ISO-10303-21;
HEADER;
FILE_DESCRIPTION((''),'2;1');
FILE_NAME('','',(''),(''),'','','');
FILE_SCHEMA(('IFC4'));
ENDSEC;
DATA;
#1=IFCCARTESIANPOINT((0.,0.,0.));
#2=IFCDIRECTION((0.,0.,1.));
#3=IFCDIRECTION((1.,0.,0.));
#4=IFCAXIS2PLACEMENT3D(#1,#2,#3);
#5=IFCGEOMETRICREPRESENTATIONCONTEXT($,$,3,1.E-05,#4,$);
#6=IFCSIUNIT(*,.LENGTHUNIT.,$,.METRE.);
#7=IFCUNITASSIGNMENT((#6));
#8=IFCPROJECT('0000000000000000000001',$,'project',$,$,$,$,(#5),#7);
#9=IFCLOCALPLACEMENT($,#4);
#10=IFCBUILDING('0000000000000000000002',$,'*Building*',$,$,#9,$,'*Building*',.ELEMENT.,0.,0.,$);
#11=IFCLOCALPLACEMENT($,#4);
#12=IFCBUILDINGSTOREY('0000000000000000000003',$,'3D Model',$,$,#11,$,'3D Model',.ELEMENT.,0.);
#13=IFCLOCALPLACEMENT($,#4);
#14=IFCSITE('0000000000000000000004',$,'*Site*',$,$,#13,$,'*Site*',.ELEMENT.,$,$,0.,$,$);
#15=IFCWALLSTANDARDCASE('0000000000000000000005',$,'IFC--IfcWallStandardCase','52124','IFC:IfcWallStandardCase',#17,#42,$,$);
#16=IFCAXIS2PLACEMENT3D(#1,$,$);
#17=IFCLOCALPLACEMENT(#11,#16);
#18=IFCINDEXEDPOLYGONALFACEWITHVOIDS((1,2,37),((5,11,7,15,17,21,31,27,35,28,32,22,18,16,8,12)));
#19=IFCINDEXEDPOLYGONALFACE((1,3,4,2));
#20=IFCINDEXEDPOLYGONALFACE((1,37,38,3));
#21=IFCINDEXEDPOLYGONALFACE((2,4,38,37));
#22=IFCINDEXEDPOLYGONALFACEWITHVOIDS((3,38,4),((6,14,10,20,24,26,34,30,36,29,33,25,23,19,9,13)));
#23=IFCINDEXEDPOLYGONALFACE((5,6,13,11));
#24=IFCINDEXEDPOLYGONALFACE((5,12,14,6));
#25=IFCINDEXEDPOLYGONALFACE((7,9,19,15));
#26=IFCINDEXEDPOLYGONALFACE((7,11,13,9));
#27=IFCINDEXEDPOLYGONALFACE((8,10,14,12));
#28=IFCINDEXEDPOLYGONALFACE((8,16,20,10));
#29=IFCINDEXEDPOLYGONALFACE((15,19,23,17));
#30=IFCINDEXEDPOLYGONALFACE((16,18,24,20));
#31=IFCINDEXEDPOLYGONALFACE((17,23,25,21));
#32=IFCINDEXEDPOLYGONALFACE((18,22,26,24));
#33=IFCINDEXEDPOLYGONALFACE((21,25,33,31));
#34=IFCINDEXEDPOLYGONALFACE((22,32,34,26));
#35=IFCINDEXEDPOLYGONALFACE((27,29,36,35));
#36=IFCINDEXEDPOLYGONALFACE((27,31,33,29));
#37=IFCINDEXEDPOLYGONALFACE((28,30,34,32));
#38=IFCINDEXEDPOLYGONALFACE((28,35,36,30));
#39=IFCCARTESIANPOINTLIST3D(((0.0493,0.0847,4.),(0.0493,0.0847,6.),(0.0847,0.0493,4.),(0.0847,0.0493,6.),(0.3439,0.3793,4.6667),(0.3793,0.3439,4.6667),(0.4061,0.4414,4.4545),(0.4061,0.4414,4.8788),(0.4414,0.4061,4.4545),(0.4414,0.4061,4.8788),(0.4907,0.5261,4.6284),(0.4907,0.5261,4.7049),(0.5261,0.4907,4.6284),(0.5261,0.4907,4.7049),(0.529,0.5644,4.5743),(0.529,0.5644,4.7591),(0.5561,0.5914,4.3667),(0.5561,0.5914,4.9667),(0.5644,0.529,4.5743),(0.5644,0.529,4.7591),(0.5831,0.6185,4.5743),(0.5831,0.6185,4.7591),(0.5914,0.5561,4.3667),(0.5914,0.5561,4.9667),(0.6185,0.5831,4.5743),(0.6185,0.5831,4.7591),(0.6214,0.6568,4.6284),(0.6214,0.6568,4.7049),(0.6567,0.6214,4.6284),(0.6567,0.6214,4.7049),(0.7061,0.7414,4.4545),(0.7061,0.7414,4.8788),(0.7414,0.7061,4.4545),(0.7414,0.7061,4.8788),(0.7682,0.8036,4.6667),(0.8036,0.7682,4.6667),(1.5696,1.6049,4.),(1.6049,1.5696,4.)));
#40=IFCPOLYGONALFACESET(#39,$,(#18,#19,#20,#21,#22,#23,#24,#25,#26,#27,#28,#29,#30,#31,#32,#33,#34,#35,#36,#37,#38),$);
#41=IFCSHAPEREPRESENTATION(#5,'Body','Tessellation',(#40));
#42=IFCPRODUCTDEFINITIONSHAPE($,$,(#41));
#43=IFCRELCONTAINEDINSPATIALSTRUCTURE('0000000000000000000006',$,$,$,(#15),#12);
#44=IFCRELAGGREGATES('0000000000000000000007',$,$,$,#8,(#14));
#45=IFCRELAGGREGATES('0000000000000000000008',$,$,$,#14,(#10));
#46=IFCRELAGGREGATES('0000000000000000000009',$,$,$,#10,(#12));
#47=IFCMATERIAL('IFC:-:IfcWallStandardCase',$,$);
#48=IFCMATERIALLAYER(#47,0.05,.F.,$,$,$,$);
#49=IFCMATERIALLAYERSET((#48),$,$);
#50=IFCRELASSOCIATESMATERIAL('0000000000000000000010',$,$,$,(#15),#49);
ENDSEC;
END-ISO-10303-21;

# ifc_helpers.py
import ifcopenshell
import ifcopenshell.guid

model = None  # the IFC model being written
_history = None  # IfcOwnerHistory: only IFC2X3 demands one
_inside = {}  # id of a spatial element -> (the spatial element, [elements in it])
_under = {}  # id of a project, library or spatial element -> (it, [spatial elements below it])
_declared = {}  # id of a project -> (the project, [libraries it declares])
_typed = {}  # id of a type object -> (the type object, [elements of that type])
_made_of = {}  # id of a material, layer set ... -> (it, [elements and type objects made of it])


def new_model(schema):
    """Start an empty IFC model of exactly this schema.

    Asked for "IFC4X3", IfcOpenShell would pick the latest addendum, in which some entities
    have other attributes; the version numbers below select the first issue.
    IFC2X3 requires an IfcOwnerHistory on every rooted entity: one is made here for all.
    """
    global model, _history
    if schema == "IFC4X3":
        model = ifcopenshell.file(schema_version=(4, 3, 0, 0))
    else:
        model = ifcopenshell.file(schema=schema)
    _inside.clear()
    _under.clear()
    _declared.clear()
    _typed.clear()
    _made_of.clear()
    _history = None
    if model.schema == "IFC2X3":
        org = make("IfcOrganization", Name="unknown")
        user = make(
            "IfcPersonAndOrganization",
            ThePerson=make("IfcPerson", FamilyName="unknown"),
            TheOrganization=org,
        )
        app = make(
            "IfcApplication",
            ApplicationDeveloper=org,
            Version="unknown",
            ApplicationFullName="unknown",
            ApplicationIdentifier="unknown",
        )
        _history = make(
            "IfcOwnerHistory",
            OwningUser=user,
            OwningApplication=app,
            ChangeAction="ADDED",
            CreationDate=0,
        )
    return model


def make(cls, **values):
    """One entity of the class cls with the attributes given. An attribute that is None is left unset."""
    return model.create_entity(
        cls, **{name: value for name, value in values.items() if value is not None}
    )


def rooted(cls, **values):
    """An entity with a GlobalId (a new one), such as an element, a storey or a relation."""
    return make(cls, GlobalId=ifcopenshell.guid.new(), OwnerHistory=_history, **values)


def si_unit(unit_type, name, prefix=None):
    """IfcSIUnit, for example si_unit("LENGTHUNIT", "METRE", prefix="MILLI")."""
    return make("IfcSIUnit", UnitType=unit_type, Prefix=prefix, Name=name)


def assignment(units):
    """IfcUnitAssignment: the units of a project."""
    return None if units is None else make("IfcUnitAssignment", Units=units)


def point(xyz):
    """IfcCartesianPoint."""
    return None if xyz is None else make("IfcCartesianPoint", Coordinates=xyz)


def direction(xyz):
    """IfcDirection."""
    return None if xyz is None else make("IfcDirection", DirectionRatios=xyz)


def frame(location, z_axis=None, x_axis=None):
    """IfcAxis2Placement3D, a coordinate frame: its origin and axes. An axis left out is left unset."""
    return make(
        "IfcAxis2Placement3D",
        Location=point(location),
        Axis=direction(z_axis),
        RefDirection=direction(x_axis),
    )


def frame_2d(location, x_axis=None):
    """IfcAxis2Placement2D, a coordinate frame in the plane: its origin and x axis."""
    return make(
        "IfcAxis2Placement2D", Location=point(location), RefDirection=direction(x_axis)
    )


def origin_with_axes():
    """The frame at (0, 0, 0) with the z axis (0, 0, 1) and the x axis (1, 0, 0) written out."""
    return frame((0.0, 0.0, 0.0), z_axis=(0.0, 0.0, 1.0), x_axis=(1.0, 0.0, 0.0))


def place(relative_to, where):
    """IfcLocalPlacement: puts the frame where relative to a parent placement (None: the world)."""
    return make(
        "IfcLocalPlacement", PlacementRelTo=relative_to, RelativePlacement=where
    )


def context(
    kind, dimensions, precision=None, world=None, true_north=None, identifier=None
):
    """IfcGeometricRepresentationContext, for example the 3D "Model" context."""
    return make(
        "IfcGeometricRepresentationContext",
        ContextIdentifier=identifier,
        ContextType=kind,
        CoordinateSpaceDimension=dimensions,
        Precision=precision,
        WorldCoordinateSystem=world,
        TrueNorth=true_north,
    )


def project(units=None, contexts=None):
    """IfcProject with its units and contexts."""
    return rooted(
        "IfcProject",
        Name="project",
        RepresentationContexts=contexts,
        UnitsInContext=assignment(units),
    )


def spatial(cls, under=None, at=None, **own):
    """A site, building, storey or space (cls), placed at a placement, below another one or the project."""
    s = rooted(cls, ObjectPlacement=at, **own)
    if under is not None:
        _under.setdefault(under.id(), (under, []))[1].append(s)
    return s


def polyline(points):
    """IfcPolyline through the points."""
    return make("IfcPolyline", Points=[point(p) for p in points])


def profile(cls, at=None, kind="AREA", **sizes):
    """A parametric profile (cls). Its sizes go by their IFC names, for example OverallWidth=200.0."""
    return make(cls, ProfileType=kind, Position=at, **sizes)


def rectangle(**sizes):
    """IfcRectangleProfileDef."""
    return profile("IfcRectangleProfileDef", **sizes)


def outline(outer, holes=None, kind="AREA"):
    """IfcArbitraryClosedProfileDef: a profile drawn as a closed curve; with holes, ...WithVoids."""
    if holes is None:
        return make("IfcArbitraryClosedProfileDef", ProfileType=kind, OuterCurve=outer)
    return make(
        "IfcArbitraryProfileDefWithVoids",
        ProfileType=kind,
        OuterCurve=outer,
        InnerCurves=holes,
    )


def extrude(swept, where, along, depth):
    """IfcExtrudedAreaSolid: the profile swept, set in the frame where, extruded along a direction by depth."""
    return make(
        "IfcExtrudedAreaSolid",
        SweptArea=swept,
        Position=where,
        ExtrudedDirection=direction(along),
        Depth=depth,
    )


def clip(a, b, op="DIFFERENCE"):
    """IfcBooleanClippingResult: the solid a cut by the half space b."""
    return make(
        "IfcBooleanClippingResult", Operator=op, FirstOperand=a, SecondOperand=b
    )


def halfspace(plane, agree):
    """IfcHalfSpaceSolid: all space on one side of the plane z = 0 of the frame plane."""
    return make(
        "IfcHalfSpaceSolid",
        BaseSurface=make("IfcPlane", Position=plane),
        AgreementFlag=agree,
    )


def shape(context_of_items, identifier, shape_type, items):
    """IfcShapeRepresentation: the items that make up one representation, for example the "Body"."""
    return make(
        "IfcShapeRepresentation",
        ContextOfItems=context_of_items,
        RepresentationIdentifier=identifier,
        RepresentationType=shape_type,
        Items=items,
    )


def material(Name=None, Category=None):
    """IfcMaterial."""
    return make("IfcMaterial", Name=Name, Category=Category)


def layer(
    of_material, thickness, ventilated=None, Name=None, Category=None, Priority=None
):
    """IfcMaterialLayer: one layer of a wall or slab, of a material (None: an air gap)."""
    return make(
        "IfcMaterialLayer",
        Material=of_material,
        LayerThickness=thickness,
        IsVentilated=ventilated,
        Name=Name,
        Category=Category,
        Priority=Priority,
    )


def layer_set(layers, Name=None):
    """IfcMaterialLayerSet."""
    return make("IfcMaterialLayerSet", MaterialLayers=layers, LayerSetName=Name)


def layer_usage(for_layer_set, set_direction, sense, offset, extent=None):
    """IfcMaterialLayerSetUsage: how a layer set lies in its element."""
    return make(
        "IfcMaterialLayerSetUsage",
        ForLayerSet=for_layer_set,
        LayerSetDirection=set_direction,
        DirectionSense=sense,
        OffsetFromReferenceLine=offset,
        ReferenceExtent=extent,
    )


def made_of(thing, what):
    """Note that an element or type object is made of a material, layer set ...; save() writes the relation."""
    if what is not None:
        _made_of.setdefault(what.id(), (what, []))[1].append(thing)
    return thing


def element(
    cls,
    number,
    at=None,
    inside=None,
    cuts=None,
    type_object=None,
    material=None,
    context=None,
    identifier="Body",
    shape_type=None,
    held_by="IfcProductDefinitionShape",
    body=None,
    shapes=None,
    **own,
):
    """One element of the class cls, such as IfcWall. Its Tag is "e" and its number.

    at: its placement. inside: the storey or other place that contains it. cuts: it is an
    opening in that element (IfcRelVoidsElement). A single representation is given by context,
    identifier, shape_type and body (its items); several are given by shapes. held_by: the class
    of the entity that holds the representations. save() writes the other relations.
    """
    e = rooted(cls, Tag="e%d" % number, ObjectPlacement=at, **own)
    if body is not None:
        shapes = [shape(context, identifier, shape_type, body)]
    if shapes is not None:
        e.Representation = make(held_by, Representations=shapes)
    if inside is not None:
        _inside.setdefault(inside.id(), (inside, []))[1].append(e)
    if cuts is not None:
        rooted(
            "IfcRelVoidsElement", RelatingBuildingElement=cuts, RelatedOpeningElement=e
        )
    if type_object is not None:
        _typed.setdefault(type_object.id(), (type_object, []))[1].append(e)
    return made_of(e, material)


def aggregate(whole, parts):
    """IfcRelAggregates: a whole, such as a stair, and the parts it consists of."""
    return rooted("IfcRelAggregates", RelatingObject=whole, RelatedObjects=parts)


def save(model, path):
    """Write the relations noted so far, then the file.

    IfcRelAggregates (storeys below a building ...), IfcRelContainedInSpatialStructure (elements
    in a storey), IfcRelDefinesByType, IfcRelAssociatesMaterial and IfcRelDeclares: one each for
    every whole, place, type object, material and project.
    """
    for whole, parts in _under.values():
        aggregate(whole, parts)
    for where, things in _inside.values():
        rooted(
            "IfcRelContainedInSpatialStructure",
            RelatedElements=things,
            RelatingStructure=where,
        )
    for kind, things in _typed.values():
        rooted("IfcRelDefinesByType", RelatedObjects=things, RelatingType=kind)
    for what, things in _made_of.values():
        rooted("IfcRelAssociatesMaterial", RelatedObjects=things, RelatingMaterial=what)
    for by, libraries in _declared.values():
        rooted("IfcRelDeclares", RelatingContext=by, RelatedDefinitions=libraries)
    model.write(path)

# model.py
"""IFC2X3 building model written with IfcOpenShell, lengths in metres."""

from ifc_helpers import new_model, si_unit, frame, frame_2d, origin_with_axes, place, context, project, spatial, polyline, rectangle, outline, extrude, clip, halfspace, material, layer, layer_set, layer_usage, element, save


model = new_model("IFC2X3")

# Units and contexts
context_of_model = context(None, 3, precision=1e-05, world=origin_with_axes())
ifc_project = project(units=[si_unit("LENGTHUNIT", "METRE")], contexts=[context_of_model])

# Site, building, storey
site_placement = place(None, origin_with_axes())
site = spatial("IfcSite", under=ifc_project, at=site_placement, Name="*Site*", LongName="*Site*", CompositionType="ELEMENT", RefElevation=0.0)
building_placement = place(None, origin_with_axes())
building = spatial("IfcBuilding", under=site, at=building_placement, Name="*Building*", LongName="*Building*", CompositionType="ELEMENT", ElevationOfRefHeight=0.0, ElevationOfTerrain=0.0)
storey_placement = place(None, origin_with_axes())
storey = spatial("IfcBuildingStorey", under=building, at=storey_placement, Name="3D Model", LongName="3D Model", CompositionType="ELEMENT", Elevation=0.0)

# Wall, opening
ifc_material = material(Name="IFC:-:IfcWallStandardCase")
ifc_layer = layer(ifc_material, 0.05, ventilated=False)
ifc_layer_set = layer_set([ifc_layer])
ifc_layer_usage = layer_usage(ifc_layer_set, "AXIS2", "POSITIVE", 0.0)
wall_1_placement = place(None, frame((0.067, 0.067, 4.0), z_axis=(0.0, 0.0, 1.0), x_axis=(0.707105, 0.707109, 0.0)))
wall_1 = element("IfcWallStandardCase", 1, at=wall_1_placement, inside=storey, material=ifc_layer_usage, Name="IFC--IfcWallStandardCase", Description="52124", ObjectType="IFC:IfcWallStandardCase", context=context_of_model, shape_type="Clipping", body=[
    clip(extrude(rectangle(XDim=2.15, YDim=0.05, at=frame_2d((1.075, 0.0), x_axis=(1.0, 0.0))), origin_with_axes(), (0.0, 0.0, 1.0), 2.0), halfspace(frame((0.9974, 0.0, 1.0722), z_axis=(-0.681104, 0.000002, -0.732187), x_axis=(-0.732187, 0.0, 0.681104)), True)),
])
opening_1_placement = place(wall_1_placement, frame((0.4167, -0.025, 0.3667), z_axis=(0.0, 0.0, 1.0), x_axis=(1.0, 0.0, 0.0)))
element("IfcOpeningElement", 2, at=opening_1_placement, cuts=wall_1, context=context_of_model, shape_type="SweptSolid", body=[
    extrude(outline(polyline([(-0.3924, 0.2617), (-0.5121, 0.0879), (-0.3383, 0.2076), (-0.3, 0.0), (-0.2617, 0.2076), (-0.0879, 0.0879), (-0.2076, 0.2617), (0.0, 0.3), (-0.2076, 0.3383), (-0.0879, 0.5121), (-0.2617, 0.3924), (-0.3, 0.6), (-0.3383, 0.3924), (-0.5121, 0.5121), (-0.3924, 0.3383), (-0.6, 0.3), (-0.3924, 0.2617)])), frame((0.0, 0.0, 0.0), z_axis=(0.0, 1.0, 0.0), x_axis=(-1.0, 0.0, 0.0)), (0.0, 0.0, 1.0), 0.075),
])

save(model, "model.ifc")
